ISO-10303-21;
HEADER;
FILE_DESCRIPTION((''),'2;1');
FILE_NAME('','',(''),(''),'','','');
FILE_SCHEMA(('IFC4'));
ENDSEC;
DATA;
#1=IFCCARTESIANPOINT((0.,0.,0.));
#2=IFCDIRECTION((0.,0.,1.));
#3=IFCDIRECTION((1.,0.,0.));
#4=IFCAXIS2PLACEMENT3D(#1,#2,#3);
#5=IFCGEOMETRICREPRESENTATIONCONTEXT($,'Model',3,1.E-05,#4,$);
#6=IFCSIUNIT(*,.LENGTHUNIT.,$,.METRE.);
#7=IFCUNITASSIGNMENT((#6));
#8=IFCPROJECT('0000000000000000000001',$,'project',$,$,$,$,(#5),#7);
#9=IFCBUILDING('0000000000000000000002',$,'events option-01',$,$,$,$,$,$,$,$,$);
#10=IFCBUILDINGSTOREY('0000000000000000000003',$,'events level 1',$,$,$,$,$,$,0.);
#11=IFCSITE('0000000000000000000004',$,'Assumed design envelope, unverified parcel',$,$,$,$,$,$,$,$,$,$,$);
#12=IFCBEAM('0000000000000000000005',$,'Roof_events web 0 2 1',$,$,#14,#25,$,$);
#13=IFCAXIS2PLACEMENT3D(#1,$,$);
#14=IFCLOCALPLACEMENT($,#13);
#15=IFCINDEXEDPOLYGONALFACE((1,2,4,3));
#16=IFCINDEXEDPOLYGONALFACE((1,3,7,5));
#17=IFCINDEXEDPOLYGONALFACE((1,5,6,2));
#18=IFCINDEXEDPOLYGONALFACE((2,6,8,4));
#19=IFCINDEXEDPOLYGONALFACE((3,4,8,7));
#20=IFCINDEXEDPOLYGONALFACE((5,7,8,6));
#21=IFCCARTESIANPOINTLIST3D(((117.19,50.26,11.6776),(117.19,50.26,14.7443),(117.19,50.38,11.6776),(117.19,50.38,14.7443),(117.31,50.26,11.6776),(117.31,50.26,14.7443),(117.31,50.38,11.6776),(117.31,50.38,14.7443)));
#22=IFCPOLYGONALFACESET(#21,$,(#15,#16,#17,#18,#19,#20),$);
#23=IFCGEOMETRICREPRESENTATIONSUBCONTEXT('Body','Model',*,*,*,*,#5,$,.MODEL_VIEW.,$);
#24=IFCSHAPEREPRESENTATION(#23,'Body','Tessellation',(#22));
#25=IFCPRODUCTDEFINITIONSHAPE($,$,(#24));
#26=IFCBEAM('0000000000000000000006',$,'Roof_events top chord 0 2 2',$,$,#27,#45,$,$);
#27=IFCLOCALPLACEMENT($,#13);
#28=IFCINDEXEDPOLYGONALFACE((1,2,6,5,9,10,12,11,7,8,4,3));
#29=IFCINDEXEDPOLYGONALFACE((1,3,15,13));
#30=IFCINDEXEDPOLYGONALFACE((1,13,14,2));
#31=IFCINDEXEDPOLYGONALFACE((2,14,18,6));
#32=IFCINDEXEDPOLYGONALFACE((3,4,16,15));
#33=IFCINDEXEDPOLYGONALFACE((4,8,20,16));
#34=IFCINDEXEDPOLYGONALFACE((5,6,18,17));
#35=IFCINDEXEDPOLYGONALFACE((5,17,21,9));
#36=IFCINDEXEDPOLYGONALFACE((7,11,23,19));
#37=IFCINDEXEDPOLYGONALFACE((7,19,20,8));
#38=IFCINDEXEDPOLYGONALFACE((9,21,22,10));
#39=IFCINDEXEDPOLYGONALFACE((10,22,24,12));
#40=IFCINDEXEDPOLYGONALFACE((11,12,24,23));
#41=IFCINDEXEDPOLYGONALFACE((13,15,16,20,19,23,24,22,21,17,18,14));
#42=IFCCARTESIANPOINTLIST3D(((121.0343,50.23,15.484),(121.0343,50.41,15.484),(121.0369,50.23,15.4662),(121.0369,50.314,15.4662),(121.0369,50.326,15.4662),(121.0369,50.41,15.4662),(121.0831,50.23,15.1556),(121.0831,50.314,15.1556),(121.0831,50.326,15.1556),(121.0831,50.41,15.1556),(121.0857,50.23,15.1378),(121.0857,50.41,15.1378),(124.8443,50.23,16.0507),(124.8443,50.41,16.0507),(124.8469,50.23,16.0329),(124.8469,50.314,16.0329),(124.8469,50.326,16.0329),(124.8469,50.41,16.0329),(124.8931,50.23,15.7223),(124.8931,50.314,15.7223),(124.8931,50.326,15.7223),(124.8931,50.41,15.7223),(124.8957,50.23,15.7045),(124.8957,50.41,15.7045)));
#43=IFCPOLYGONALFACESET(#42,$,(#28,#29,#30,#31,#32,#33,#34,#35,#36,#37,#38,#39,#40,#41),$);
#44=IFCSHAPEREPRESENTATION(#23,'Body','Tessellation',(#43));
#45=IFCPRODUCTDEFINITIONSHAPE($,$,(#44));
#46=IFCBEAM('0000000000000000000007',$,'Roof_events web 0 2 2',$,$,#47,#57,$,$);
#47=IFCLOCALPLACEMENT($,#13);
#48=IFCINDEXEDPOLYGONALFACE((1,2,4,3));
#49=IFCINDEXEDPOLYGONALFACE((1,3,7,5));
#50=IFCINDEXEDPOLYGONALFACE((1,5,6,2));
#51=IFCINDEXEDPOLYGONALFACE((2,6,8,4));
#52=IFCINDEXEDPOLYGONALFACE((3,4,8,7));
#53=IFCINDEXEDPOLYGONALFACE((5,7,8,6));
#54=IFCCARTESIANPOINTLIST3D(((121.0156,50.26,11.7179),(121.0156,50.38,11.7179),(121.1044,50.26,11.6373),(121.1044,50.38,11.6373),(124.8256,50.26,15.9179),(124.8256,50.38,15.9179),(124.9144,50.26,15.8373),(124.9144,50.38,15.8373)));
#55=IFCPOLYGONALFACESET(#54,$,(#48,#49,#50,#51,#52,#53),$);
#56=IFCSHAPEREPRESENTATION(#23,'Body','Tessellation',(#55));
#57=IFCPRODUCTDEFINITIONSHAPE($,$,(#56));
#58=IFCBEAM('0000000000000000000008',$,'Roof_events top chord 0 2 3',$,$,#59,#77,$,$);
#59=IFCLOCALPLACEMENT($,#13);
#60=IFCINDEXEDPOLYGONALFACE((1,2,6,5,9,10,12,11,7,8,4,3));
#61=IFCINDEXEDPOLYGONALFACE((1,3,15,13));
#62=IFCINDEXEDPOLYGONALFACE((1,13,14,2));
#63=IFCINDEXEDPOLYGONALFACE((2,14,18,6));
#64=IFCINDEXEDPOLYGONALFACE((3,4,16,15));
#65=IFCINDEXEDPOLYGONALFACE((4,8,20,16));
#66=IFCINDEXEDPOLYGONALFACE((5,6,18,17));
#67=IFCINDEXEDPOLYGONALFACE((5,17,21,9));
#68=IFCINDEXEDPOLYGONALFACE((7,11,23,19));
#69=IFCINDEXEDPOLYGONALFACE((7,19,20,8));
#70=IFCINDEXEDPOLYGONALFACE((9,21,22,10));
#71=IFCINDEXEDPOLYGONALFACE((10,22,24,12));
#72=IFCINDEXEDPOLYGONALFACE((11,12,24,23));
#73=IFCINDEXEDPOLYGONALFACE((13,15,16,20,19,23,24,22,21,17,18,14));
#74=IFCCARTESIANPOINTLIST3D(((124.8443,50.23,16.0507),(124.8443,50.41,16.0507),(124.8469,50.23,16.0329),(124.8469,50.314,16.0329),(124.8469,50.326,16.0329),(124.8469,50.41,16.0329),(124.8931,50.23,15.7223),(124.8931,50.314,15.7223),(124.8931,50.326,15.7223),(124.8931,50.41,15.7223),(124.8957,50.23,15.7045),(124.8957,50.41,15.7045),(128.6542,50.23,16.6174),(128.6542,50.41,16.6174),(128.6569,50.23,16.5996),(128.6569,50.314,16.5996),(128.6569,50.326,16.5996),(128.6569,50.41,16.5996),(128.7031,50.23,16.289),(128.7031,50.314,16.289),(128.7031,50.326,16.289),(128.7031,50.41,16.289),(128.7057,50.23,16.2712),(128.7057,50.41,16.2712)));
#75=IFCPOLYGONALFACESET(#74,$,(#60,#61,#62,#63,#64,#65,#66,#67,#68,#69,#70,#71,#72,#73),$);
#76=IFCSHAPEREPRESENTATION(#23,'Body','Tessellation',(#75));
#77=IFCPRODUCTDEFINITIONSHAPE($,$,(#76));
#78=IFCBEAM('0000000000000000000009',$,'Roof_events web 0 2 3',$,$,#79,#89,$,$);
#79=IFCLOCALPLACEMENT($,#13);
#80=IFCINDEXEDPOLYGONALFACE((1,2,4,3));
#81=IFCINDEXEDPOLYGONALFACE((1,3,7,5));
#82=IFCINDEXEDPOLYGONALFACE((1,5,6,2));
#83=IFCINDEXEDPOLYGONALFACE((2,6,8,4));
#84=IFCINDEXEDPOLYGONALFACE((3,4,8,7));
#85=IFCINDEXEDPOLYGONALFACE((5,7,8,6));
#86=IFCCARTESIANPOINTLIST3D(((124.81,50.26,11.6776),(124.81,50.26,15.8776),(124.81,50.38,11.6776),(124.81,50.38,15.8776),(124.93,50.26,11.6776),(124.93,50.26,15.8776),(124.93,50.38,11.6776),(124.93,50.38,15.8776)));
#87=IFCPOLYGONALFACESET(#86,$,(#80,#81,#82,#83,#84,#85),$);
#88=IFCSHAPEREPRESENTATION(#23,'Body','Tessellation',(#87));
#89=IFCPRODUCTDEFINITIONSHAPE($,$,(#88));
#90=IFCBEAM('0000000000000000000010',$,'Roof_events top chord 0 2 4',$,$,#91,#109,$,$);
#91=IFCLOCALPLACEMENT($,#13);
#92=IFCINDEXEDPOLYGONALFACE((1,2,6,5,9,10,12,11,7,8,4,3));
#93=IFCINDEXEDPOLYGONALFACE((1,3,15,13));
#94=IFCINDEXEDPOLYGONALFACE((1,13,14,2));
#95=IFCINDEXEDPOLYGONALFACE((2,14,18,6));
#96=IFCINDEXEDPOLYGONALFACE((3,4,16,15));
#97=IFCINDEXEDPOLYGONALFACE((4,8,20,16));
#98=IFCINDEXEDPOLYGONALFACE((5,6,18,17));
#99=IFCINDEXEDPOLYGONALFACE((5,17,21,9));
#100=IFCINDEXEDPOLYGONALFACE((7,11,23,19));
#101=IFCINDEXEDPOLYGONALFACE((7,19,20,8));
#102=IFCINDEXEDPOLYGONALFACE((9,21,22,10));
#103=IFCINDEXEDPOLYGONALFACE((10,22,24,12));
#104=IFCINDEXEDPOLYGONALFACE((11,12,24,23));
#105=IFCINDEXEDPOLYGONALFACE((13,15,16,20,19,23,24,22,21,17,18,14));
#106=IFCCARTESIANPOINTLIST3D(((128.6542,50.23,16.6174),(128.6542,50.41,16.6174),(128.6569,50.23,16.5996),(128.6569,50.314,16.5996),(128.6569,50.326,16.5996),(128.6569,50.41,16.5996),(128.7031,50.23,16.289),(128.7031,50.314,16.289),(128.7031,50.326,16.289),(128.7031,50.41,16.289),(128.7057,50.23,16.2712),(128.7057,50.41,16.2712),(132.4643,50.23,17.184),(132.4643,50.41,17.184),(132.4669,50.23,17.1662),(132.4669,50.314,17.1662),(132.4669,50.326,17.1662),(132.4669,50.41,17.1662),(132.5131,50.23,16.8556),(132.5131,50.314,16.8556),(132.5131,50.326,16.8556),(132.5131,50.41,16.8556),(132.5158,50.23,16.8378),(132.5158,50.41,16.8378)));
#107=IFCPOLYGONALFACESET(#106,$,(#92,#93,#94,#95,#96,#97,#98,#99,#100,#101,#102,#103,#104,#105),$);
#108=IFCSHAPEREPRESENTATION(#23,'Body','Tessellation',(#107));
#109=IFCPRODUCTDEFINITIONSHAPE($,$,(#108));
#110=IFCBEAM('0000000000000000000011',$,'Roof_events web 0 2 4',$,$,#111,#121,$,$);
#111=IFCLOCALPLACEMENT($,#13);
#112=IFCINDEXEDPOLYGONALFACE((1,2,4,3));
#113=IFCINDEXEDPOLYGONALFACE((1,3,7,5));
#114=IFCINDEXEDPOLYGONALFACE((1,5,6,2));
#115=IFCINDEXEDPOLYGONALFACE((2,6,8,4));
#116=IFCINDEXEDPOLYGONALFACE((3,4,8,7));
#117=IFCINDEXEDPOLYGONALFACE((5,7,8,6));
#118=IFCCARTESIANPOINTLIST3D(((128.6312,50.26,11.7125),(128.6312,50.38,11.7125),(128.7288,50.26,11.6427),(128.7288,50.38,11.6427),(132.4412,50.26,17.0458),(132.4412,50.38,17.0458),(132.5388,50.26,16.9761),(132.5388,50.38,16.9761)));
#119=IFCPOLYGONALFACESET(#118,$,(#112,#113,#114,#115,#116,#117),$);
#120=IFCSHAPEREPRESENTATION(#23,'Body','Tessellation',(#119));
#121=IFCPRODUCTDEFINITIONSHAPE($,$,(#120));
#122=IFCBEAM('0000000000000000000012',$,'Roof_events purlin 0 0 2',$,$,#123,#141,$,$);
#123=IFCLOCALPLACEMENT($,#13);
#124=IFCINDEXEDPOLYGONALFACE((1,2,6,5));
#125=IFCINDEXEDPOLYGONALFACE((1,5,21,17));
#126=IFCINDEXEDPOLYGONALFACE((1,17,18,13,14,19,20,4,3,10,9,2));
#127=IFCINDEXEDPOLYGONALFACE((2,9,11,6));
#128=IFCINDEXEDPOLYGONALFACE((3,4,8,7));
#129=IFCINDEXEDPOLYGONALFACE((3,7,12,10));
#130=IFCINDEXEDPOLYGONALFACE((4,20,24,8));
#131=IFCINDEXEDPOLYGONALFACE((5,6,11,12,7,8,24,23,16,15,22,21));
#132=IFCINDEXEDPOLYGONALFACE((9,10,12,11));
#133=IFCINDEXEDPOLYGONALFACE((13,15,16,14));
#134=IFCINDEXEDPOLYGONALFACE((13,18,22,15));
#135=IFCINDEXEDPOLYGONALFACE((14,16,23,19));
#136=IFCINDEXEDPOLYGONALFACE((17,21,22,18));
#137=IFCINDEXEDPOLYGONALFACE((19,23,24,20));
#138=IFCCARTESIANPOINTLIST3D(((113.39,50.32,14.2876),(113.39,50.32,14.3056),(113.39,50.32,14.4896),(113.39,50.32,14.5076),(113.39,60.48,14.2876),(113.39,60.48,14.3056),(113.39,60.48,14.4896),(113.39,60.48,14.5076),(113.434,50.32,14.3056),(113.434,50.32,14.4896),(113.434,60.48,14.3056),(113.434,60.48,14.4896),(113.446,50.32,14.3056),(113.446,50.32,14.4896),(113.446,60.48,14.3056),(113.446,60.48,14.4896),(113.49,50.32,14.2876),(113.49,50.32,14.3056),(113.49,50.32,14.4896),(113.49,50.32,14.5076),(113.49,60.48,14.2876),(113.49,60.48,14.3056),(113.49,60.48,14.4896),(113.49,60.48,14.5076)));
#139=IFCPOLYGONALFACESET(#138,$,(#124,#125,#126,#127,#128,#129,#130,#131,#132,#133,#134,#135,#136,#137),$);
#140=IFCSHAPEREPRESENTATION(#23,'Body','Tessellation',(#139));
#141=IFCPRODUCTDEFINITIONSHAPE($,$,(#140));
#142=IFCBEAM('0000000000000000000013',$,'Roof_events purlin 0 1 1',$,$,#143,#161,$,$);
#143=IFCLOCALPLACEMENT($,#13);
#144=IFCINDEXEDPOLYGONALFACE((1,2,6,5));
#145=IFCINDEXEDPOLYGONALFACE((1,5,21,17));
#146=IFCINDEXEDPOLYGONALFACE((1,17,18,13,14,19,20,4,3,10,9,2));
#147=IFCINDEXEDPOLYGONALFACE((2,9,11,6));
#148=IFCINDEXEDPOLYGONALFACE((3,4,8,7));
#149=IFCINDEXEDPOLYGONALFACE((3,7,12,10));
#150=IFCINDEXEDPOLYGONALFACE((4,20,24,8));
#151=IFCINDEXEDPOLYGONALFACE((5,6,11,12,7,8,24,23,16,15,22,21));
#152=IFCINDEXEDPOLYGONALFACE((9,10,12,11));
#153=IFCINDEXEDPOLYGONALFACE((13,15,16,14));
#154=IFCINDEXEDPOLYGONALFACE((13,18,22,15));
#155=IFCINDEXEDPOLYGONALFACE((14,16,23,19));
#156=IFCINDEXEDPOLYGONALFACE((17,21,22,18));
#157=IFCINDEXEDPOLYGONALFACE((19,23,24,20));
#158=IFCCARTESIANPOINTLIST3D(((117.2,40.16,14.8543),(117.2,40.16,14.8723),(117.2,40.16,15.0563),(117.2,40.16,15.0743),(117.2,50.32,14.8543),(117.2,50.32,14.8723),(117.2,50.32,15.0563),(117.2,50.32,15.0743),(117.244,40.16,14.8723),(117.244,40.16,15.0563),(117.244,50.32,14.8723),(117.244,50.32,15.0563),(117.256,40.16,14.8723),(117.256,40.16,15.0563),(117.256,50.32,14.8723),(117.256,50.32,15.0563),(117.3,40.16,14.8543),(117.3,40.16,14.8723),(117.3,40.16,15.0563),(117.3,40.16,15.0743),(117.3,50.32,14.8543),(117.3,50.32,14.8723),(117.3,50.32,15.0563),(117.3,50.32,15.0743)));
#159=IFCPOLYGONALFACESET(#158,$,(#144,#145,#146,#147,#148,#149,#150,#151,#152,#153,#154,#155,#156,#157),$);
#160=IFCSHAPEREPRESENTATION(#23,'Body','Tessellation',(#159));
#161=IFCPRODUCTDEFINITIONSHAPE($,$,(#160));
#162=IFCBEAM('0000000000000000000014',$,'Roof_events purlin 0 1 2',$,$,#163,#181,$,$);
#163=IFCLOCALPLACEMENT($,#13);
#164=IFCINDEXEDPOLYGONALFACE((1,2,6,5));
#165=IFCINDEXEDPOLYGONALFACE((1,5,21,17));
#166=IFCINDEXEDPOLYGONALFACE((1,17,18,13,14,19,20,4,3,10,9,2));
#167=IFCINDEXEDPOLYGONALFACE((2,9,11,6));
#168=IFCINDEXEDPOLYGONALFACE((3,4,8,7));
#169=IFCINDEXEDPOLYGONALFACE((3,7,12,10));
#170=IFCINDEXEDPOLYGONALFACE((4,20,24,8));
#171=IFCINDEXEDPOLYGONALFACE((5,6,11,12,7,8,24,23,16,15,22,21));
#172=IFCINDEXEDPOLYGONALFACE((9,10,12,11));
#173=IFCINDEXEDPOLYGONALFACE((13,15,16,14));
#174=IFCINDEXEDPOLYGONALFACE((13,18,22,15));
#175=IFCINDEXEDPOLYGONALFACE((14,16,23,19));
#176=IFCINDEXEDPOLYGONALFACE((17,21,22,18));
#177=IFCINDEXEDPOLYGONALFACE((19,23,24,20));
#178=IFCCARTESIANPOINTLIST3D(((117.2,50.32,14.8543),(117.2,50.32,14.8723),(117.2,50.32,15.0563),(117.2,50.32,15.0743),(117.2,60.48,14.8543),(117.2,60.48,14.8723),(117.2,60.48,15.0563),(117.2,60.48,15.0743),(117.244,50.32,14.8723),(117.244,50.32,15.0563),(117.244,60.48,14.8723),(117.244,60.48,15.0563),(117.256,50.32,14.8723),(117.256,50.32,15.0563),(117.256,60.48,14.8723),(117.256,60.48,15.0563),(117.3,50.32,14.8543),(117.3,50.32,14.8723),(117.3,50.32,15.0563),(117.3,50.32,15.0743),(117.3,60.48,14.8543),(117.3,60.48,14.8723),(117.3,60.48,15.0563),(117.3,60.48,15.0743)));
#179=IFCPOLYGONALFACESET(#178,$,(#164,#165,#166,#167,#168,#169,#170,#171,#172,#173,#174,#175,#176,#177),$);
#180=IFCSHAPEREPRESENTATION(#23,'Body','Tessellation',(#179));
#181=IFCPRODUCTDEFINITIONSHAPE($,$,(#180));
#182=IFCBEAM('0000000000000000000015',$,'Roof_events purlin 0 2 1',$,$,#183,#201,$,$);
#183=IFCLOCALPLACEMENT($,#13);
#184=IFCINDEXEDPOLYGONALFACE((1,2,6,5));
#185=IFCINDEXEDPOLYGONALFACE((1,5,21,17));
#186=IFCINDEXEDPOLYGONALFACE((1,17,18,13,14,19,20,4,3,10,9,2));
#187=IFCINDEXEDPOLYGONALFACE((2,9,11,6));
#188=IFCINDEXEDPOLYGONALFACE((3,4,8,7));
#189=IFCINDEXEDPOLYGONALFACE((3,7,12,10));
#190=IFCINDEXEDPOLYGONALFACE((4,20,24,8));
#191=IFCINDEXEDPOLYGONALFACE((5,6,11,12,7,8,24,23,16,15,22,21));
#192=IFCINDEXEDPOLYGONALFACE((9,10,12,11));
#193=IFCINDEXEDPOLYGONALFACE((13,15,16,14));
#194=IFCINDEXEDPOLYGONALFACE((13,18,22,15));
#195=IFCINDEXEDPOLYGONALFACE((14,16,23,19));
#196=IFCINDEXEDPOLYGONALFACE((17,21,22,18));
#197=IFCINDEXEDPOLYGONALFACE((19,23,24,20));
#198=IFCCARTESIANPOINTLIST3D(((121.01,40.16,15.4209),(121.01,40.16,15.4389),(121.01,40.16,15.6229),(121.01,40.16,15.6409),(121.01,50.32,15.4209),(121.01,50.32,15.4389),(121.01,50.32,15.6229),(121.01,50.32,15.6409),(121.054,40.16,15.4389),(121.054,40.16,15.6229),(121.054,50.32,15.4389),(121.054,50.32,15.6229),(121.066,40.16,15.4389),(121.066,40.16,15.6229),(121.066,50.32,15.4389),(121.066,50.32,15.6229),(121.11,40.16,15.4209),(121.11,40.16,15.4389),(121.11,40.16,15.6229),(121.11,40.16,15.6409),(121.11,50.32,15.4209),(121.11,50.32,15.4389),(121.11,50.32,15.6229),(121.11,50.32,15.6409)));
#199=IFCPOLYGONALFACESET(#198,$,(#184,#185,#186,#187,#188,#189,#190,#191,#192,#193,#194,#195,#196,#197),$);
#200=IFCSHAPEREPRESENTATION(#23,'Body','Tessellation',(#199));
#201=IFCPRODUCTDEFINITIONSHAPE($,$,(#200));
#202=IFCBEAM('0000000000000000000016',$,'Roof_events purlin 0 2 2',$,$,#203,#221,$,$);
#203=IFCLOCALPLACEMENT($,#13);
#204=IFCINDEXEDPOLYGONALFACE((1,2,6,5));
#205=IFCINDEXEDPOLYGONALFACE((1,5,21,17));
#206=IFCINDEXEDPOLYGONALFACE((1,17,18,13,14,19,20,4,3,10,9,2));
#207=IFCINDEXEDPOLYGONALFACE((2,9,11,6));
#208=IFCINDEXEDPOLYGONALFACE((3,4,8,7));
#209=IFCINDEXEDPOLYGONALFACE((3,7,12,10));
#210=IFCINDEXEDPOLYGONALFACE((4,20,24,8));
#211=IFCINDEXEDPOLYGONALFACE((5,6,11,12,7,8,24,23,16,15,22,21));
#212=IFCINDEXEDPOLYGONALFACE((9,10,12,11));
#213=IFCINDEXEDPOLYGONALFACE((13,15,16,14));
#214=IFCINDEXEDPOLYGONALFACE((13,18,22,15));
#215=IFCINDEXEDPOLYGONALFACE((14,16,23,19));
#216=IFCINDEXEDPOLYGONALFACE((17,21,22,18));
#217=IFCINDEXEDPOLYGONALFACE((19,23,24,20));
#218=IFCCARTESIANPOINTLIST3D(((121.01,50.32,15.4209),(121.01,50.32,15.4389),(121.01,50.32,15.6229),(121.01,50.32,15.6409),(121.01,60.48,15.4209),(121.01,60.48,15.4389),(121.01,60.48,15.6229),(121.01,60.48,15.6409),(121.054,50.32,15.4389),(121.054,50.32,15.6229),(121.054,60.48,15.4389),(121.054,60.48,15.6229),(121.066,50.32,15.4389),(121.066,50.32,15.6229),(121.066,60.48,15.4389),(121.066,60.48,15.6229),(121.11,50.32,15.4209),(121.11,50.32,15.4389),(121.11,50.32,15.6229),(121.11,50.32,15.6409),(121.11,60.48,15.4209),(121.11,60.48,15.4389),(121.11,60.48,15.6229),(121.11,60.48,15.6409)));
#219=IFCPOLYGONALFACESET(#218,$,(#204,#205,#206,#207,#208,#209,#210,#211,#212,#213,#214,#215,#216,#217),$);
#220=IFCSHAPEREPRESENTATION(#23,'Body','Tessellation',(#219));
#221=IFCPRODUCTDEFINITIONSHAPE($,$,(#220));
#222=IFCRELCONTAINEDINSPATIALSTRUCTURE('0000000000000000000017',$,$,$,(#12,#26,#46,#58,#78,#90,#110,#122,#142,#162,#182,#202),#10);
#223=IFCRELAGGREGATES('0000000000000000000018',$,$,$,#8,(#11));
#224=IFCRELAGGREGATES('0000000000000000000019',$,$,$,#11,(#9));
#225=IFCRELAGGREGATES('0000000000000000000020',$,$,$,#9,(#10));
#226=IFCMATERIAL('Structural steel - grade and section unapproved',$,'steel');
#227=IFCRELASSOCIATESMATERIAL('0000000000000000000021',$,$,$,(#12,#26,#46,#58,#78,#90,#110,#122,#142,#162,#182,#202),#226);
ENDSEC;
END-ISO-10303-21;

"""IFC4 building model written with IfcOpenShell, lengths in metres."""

from ifc_helpers import new_model, si_unit, frame, origin_with_axes, place, context, subcontext, project, spatial, rectangle, i_section, extrude, material, element, save


model = new_model("IFC4")

# Units and contexts
model_context = context("Model", 3, precision=1e-05, world=origin_with_axes())
body_context = subcontext(model_context, "Body", "Model", "MODEL_VIEW")
ifc_project = project(units=[si_unit("LENGTHUNIT", "METRE")], contexts=[model_context])

# Site, building, storey
site = spatial("IfcSite", under=ifc_project, Name="Assumed design envelope, unverified parcel")
building = spatial("IfcBuilding", under=site, Name="events option-01")
storey = spatial("IfcBuildingStorey", under=building, Name="events level 1", Elevation=0.0)

# Shared definitions
ifc_material_1 = material(Name="Structural steel - grade and section unapproved", Category="steel")

# Beams
beam_1_placement = place(None, frame((117.25, 50.32, 11.6776), z_axis=(0.0, 0.0, 1.0), x_axis=(-1.0, 0.0, 0.0)))
element("IfcBeam", 1, at=beam_1_placement, inside=storey, material=ifc_material_1, Name="Roof_events web 0 2 1", context=body_context, shape_type="SweptSolid", body=[
    extrude(rectangle(XDim=0.12, YDim=0.12), origin_with_axes(), (0.0, 0.0, 1.0), 3.0667),
])
beam_2_placement = place(None, frame((121.06, 50.32, 15.3109), z_axis=(0.98912, 0.0, 0.147113), x_axis=(0.0, 1.0, 0.0)))
element("IfcBeam", 2, at=beam_2_placement, inside=storey, material=ifc_material_1, Name="Roof_events top chord 0 2 2", context=body_context, shape_type="SweptSolid", body=[
    extrude(i_section(OverallWidth=0.18, OverallDepth=0.35, WebThickness=0.012, FlangeThickness=0.018, FilletRadius=0.0), origin_with_axes(), (0.0, 0.0, 1.0), 3.8519),
])
beam_3_placement = place(None, frame((121.06, 50.32, 11.6776), z_axis=(0.671883, 0.0, 0.740657), x_axis=(0.0, 1.0, 0.0)))
element("IfcBeam", 3, at=beam_3_placement, inside=storey, material=ifc_material_1, Name="Roof_events web 0 2 2", context=body_context, shape_type="SweptSolid", body=[
    extrude(rectangle(XDim=0.12, YDim=0.12), origin_with_axes(), (0.0, 0.0, 1.0), 5.6706),
])
beam_4_placement = place(None, frame((124.87, 50.32, 15.8776), z_axis=(0.98912, 0.0, 0.147114), x_axis=(0.0, 1.0, 0.0)))
element("IfcBeam", 4, at=beam_4_placement, inside=storey, material=ifc_material_1, Name="Roof_events top chord 0 2 3", context=body_context, shape_type="SweptSolid", body=[
    extrude(i_section(OverallWidth=0.18, OverallDepth=0.35, WebThickness=0.012, FlangeThickness=0.018, FilletRadius=0.0), origin_with_axes(), (0.0, 0.0, 1.0), 3.8519),
])
beam_5_placement = place(None, frame((124.87, 50.32, 11.6776), z_axis=(0.0, 0.0, 1.0), x_axis=(-1.0, 0.0, 0.0)))
element("IfcBeam", 5, at=beam_5_placement, inside=storey, material=ifc_material_1, Name="Roof_events web 0 2 3", context=body_context, shape_type="SweptSolid", body=[
    extrude(rectangle(XDim=0.12, YDim=0.12), origin_with_axes(), (0.0, 0.0, 1.0), 4.2),
])
beam_6_placement = place(None, frame((128.68, 50.32, 16.4443), z_axis=(0.98912, 0.0, 0.147112), x_axis=(0.0, 1.0, 0.0)))
element("IfcBeam", 6, at=beam_6_placement, inside=storey, material=ifc_material_1, Name="Roof_events top chord 0 2 4", context=body_context, shape_type="SweptSolid", body=[
    extrude(i_section(OverallWidth=0.18, OverallDepth=0.35, WebThickness=0.012, FlangeThickness=0.018, FilletRadius=0.0), origin_with_axes(), (0.0, 0.0, 1.0), 3.8519),
])
beam_7_placement = place(None, frame((128.68, 50.32, 11.6776), z_axis=(0.581288, 0.0, 0.813698), x_axis=(0.0, 1.0, 0.0)))
element("IfcBeam", 7, at=beam_7_placement, inside=storey, material=ifc_material_1, Name="Roof_events web 0 2 4", context=body_context, shape_type="SweptSolid", body=[
    extrude(rectangle(XDim=0.12, YDim=0.12), origin_with_axes(), (0.0, 0.0, 1.0), 6.5544),
])
for number, where, z_axis, x_axis, name in (
    (8, (113.44, 50.32, 14.3976), (0.0, 1.0, 0.0), (-1.0, 0.0, 0.0), "Roof_events purlin 0 0 2"),
    (9, (117.25, 40.16, 14.9643), (0.0, 1.0, 0.0), (-1.0, 0.0, 0.0), "Roof_events purlin 0 1 1"),
    (10, (117.25, 50.32, 14.9643), (0.0, 1.0, 0.0), (-1.0, 0.0, 0.0), "Roof_events purlin 0 1 2"),
    (11, (121.06, 40.16, 15.5309), (0.0, 1.0, 0.0), (-1.0, 0.0, 0.0), "Roof_events purlin 0 2 1"),
    (12, (121.06, 50.32, 15.5309), (0.0, 1.0, 0.0), (-1.0, 0.0, 0.0), "Roof_events purlin 0 2 2"),
):
    element("IfcBeam", number, at=place(None, frame(where, z_axis=z_axis, x_axis=x_axis)), inside=storey, material=ifc_material_1, Name=name, context=body_context, shape_type="SweptSolid", body=[
        extrude(i_section(OverallWidth=0.1, OverallDepth=0.22, WebThickness=0.012, FlangeThickness=0.018, FilletRadius=0.0), origin_with_axes(), (0.0, 0.0, 1.0), 10.16),
    ])

save(model, "model.ifc")
